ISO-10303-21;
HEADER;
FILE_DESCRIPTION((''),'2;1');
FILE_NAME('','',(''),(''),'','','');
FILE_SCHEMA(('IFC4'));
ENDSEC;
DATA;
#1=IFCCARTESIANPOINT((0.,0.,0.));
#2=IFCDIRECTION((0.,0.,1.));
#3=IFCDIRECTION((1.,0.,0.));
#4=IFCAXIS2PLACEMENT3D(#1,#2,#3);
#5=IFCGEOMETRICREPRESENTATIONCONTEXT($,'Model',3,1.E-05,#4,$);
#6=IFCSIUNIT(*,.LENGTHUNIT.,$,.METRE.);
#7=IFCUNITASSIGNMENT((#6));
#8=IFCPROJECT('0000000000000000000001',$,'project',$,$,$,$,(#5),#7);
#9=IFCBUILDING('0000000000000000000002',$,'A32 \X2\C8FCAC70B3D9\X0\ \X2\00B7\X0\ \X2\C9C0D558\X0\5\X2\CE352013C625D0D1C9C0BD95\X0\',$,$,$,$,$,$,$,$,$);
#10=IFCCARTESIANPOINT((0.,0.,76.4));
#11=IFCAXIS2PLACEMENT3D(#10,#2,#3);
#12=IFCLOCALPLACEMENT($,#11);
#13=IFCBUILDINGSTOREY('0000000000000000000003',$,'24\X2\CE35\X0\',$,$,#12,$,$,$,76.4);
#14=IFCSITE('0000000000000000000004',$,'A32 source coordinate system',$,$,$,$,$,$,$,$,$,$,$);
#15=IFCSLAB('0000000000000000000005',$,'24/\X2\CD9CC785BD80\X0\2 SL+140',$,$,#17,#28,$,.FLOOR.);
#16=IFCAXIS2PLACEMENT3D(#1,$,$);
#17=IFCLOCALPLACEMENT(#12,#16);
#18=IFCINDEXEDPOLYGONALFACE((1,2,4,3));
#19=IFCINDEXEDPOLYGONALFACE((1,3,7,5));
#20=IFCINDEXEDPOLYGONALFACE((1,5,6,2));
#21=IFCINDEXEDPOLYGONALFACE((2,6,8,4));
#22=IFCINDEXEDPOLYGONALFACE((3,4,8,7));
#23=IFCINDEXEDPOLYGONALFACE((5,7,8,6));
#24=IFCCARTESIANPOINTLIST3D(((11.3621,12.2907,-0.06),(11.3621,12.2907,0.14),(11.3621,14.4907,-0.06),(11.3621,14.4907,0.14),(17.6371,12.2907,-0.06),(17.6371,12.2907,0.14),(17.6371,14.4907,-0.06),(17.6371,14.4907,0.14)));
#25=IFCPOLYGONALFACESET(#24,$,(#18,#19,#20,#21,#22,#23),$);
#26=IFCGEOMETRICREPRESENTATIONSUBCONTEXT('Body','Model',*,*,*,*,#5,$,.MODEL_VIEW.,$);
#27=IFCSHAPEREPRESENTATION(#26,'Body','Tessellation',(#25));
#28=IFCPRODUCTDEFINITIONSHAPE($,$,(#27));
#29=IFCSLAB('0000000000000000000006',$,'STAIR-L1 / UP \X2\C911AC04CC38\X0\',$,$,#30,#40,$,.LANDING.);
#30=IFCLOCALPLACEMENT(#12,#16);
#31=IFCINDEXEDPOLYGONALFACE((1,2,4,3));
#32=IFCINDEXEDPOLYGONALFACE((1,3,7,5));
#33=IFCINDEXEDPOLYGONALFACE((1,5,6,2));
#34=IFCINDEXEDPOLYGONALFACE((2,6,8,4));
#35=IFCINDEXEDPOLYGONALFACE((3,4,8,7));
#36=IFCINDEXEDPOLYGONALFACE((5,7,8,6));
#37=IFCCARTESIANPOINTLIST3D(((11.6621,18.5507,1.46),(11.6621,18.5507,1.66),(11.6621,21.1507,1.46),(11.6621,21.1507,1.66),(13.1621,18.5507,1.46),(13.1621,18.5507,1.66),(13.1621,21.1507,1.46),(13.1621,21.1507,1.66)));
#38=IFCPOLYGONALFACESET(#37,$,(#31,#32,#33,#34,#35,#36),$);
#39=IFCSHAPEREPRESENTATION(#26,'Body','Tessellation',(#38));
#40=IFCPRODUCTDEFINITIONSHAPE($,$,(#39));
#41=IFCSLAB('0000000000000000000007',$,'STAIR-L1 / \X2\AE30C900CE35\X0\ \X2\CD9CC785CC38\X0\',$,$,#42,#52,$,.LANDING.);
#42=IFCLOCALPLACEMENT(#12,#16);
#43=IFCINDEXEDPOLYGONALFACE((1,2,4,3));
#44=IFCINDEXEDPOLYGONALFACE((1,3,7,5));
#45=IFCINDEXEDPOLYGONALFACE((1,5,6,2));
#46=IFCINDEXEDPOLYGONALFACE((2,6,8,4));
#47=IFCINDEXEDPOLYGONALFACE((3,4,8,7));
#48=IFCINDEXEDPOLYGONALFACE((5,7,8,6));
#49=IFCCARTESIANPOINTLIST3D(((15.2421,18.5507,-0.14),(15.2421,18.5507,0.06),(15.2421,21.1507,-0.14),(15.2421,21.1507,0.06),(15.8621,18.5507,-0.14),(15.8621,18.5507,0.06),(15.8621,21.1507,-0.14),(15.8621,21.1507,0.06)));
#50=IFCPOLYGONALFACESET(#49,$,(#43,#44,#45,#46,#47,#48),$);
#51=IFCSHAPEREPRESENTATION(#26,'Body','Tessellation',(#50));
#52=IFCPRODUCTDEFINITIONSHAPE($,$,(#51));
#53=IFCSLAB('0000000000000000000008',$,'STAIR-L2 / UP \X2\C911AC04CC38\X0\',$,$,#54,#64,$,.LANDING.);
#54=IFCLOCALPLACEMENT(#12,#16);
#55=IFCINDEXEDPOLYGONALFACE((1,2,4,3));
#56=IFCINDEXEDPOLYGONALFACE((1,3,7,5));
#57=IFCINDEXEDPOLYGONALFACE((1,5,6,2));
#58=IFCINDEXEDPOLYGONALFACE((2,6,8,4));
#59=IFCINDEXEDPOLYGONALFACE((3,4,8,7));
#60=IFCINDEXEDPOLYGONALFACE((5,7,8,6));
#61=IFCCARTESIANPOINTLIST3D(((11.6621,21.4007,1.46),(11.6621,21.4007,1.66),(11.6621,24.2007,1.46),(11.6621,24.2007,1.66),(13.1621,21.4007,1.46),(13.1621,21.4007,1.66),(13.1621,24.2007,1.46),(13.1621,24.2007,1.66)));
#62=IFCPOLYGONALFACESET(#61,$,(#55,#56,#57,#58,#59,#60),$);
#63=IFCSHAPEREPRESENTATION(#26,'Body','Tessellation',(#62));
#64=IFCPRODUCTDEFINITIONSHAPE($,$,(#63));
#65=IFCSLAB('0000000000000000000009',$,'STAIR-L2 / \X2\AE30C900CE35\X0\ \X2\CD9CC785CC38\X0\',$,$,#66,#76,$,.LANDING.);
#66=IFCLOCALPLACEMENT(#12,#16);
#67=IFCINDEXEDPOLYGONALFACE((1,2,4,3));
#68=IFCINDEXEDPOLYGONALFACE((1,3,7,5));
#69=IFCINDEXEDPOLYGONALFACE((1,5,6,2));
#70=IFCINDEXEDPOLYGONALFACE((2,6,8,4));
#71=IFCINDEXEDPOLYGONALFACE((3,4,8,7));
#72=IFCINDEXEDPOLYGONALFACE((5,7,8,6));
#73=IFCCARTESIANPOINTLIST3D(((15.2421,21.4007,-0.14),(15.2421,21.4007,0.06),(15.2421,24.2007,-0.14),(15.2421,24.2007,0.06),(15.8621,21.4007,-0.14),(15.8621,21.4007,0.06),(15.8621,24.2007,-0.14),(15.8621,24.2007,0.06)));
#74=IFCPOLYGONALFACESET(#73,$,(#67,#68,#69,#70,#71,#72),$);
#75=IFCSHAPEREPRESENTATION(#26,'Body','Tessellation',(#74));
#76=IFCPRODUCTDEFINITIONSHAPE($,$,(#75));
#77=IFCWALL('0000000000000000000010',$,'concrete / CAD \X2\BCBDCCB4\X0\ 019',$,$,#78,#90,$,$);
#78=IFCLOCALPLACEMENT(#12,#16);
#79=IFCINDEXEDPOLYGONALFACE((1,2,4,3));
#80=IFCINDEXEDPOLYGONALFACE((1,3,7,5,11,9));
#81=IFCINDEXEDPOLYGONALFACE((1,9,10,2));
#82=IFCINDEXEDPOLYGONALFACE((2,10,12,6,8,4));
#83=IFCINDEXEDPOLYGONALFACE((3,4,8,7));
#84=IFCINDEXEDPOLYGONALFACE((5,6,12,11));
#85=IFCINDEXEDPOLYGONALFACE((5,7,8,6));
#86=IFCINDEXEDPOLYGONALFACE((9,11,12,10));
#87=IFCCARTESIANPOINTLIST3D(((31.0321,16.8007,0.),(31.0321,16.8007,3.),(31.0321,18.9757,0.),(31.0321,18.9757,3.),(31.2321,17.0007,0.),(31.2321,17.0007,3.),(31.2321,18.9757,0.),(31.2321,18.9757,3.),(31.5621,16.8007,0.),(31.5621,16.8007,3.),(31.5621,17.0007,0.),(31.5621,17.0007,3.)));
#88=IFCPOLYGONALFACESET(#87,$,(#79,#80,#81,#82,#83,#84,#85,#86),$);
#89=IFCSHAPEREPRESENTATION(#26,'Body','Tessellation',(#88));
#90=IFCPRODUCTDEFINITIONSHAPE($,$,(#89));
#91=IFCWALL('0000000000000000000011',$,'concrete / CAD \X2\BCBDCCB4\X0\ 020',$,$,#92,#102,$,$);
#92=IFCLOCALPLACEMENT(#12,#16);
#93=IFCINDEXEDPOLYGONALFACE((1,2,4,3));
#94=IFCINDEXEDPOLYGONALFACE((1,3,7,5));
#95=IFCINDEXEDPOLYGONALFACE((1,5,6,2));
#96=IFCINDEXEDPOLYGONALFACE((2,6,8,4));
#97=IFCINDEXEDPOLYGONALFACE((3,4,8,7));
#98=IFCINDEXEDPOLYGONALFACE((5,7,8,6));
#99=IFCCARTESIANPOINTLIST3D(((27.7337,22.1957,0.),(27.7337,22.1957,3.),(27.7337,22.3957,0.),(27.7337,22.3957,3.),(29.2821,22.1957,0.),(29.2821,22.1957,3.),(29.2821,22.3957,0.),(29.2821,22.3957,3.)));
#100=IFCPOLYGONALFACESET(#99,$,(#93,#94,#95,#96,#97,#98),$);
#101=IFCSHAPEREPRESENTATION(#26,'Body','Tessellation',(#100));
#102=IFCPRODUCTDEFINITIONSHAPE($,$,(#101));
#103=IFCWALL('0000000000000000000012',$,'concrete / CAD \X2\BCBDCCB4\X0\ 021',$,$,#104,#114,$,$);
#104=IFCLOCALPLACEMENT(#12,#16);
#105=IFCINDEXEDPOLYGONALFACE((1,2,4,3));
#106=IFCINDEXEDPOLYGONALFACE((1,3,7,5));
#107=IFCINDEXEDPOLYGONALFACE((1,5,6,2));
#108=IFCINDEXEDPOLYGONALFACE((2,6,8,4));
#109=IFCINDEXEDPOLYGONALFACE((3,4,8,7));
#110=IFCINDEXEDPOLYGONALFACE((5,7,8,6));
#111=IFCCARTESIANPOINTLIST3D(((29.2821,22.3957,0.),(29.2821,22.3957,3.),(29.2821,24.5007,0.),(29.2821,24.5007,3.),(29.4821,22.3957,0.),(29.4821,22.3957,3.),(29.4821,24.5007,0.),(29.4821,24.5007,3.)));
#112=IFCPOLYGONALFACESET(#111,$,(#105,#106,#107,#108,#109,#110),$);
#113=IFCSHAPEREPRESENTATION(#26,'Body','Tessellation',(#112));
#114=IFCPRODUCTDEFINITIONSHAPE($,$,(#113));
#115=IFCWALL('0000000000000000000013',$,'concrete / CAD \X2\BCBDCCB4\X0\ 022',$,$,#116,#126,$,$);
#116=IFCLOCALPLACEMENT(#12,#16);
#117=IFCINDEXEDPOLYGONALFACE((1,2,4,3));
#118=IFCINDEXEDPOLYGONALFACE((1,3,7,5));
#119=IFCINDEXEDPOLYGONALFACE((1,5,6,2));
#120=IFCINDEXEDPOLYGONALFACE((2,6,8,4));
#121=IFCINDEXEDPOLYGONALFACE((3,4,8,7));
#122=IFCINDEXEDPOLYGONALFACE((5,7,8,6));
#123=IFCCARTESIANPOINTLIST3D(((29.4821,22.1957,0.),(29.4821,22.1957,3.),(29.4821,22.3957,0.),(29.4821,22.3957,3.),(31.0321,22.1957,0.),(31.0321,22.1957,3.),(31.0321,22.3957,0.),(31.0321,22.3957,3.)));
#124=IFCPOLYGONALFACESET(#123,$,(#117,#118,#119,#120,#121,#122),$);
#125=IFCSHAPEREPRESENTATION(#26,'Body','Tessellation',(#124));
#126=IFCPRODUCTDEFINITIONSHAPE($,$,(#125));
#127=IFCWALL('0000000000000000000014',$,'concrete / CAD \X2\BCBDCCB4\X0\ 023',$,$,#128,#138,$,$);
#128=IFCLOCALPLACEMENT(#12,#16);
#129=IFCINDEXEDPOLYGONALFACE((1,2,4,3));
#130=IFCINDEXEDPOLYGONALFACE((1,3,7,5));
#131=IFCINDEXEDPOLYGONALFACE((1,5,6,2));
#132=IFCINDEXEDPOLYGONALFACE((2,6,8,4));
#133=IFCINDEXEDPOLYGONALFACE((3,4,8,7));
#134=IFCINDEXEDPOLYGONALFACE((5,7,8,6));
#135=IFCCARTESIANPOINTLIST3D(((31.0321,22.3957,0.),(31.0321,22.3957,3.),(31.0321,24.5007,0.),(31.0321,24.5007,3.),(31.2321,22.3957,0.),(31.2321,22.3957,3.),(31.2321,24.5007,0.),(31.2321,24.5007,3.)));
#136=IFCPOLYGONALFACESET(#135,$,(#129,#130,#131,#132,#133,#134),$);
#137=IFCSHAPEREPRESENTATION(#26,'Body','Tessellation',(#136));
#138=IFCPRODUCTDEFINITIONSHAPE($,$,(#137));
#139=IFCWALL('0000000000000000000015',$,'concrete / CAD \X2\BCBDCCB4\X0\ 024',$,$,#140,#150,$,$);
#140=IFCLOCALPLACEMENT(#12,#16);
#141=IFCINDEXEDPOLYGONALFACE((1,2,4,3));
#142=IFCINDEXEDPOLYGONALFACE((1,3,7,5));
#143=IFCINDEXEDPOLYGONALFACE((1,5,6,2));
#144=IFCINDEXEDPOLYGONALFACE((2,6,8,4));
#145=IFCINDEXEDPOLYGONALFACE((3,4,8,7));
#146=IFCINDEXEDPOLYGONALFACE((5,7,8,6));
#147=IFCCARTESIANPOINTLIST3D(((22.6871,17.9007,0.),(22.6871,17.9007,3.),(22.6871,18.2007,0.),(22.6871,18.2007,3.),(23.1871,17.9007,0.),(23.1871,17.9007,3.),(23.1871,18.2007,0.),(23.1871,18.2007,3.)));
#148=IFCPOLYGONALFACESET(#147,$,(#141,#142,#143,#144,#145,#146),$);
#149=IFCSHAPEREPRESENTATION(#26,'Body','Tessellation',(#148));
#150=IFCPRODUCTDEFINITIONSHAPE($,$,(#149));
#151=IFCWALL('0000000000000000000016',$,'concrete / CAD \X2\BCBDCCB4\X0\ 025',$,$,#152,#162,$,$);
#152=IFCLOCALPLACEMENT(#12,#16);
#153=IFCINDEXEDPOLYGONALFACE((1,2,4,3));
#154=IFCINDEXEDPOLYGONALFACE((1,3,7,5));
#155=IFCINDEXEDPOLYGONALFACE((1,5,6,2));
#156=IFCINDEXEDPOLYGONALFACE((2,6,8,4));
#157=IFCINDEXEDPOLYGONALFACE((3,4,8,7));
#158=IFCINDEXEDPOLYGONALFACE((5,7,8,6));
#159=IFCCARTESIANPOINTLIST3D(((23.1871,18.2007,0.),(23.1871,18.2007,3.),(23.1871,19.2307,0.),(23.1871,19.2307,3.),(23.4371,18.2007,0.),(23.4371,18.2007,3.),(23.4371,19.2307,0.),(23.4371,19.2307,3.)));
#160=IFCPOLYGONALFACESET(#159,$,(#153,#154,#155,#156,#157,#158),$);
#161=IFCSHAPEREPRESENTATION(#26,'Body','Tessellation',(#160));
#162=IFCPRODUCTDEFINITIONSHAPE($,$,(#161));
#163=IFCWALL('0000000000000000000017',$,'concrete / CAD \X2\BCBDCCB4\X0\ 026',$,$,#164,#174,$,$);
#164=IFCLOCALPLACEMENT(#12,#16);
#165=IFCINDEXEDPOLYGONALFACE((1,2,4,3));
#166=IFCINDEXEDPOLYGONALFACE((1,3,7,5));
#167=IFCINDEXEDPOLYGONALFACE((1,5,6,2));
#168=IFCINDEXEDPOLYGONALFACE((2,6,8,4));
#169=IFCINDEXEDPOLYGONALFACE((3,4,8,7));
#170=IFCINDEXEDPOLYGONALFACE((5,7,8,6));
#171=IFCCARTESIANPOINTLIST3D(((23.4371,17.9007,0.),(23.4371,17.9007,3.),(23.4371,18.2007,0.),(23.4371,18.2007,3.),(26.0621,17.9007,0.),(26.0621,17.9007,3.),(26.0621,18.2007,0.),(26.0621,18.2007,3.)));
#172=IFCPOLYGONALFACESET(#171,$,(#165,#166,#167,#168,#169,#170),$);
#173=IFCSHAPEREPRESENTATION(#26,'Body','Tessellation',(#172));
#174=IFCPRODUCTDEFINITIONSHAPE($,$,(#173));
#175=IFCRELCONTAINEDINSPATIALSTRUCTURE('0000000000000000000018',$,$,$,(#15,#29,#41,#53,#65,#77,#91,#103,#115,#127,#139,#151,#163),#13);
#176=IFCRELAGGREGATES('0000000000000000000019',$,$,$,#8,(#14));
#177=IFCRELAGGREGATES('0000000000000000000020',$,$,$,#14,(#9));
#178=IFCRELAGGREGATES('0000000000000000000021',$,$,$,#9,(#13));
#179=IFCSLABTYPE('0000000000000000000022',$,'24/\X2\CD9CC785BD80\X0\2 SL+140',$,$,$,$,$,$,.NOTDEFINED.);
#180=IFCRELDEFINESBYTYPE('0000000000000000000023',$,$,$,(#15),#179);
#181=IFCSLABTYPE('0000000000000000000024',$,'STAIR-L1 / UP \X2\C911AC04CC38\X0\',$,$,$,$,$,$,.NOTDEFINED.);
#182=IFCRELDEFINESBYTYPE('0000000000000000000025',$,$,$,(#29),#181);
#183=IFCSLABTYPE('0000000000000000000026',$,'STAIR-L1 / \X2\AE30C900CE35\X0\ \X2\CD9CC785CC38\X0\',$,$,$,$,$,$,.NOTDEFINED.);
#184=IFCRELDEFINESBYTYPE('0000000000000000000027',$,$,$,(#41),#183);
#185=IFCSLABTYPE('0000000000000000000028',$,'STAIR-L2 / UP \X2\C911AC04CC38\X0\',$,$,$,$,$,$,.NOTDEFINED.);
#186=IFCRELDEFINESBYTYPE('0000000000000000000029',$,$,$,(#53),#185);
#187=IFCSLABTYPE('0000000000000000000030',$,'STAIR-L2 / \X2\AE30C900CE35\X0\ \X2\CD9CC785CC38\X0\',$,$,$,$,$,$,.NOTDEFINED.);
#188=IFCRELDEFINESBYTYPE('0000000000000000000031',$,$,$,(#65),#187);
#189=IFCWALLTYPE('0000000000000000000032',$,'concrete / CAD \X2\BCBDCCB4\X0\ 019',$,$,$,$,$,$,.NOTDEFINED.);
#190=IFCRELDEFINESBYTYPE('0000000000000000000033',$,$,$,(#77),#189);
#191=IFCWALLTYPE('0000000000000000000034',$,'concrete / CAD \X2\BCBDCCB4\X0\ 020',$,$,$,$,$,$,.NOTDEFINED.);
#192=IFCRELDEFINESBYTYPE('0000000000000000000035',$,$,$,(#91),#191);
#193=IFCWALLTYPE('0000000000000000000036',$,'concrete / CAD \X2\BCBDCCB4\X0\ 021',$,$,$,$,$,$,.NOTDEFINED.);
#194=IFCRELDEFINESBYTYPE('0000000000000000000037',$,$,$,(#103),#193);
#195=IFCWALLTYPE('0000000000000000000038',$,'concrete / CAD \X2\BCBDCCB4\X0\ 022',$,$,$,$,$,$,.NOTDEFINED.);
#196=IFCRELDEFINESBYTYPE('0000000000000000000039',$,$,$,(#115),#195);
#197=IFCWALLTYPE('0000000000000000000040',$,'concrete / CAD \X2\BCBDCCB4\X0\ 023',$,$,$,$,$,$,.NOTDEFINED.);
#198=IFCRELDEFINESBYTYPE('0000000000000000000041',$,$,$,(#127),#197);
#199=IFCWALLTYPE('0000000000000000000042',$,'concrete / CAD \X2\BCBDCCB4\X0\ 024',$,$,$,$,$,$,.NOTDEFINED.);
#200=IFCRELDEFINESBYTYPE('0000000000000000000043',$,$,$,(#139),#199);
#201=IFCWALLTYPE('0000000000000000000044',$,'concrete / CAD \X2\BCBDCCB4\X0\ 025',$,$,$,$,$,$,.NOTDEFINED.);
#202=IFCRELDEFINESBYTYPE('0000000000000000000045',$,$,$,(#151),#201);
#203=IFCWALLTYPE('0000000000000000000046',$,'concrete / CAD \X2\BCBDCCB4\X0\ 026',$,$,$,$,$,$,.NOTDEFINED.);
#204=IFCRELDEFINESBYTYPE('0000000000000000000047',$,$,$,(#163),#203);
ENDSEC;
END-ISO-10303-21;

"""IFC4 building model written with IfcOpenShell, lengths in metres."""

from ifc_helpers import new_model, si_unit, frame, origin, origin_with_axes, place, context, subcontext, project, spatial, polyline, outline, extrude, source, transform, mapped, type_object, type_shapes, element, save


model = new_model("IFC4")

# Units and contexts
model_context = context("Model", 3, precision=1e-05, world=origin_with_axes())
body_context = subcontext(model_context, "Body", "Model", "MODEL_VIEW")
ifc_project = project(units=[si_unit("LENGTHUNIT", "METRE")], contexts=[model_context])

# Site, building, storey
site = spatial("IfcSite", under=ifc_project, Name="A32 source coordinate system")
building = spatial("IfcBuilding", under=site, Name="A32 주거동 · 지하5층–옥탑지붕")
storey_placement = place(None, frame((0.0, 0.0, 76.4), z_axis=(0.0, 0.0, 1.0), x_axis=(1.0, 0.0, 0.0)))
storey = spatial("IfcBuildingStorey", under=building, at=storey_placement, Name="24층", Elevation=76.4)

# Slabs
slab_type_1 = type_object("IfcSlabType", Name="24/출입부2 SL+140", PredefinedType="NOTDEFINED")
shared_shape_1 = source(origin(), body_context, "Body", "SweptSolid", [
    extrude(outline(polyline([(17.6371, 12.2907), (11.3621, 12.2907), (11.3621, 14.4907), (17.6371, 14.4907), (17.6371, 12.2907)])), frame((0.0, 0.0, -0.06)), (0.0, 0.0, 1.0), 0.2),
])
type_shapes(slab_type_1, [shared_shape_1])
slab_1_placement = place(storey_placement, origin_with_axes())
element("IfcSlab", 1, at=slab_1_placement, inside=storey, type_object=slab_type_1, Name="24/출입부2 SL+140", PredefinedType="FLOOR", context=body_context, shape_type="MappedRepresentation", body=[
    mapped(shared_shape_1, transform((0.0, 0.0, 0.0), scale=1.0)),
])
slab_type_2 = type_object("IfcSlabType", Name="STAIR-L1 / UP 중간참", PredefinedType="NOTDEFINED")
shared_shape_2 = source(origin(), body_context, "Body", "SweptSolid", [
    extrude(outline(polyline([(11.6621, 18.5507), (11.6621, 21.1507), (13.1621, 21.1507), (13.1621, 18.5507), (11.6621, 18.5507)])), frame((0.0, 0.0, 1.46)), (0.0, 0.0, 1.0), 0.2),
])
type_shapes(slab_type_2, [shared_shape_2])
slab_2_placement = place(storey_placement, origin_with_axes())
element("IfcSlab", 2, at=slab_2_placement, inside=storey, type_object=slab_type_2, Name="STAIR-L1 / UP 중간참", PredefinedType="LANDING", context=body_context, shape_type="MappedRepresentation", body=[
    mapped(shared_shape_2, transform((0.0, 0.0, 0.0), scale=1.0)),
])
slab_type_3 = type_object("IfcSlabType", Name="STAIR-L1 / 기준층 출입참", PredefinedType="NOTDEFINED")
shared_shape_3 = source(origin(), body_context, "Body", "SweptSolid", [
    extrude(outline(polyline([(15.2421, 18.5507), (15.2421, 21.1507), (15.8621, 21.1507), (15.8621, 18.5507), (15.2421, 18.5507)])), frame((0.0, 0.0, -0.14)), (0.0, 0.0, 1.0), 0.2),
])
type_shapes(slab_type_3, [shared_shape_3])
slab_3_placement = place(storey_placement, origin_with_axes())
element("IfcSlab", 3, at=slab_3_placement, inside=storey, type_object=slab_type_3, Name="STAIR-L1 / 기준층 출입참", PredefinedType="LANDING", context=body_context, shape_type="MappedRepresentation", body=[
    mapped(shared_shape_3, transform((0.0, 0.0, 0.0), scale=1.0)),
])
slab_type_4 = type_object("IfcSlabType", Name="STAIR-L2 / UP 중간참", PredefinedType="NOTDEFINED")
shared_shape_4 = source(origin(), body_context, "Body", "SweptSolid", [
    extrude(outline(polyline([(11.6621, 21.4007), (11.6621, 24.2007), (13.1621, 24.2007), (13.1621, 21.4007), (11.6621, 21.4007)])), frame((0.0, 0.0, 1.46)), (0.0, 0.0, 1.0), 0.2),
])
type_shapes(slab_type_4, [shared_shape_4])
slab_4_placement = place(storey_placement, origin_with_axes())
element("IfcSlab", 4, at=slab_4_placement, inside=storey, type_object=slab_type_4, Name="STAIR-L2 / UP 중간참", PredefinedType="LANDING", context=body_context, shape_type="MappedRepresentation", body=[
    mapped(shared_shape_4, transform((0.0, 0.0, 0.0), scale=1.0)),
])
slab_type_5 = type_object("IfcSlabType", Name="STAIR-L2 / 기준층 출입참", PredefinedType="NOTDEFINED")
shared_shape_5 = source(origin(), body_context, "Body", "SweptSolid", [
    extrude(outline(polyline([(15.2421, 21.4007), (15.2421, 24.2007), (15.8621, 24.2007), (15.8621, 21.4007), (15.2421, 21.4007)])), frame((0.0, 0.0, -0.14)), (0.0, 0.0, 1.0), 0.2),
])
type_shapes(slab_type_5, [shared_shape_5])
slab_5_placement = place(storey_placement, origin_with_axes())
element("IfcSlab", 5, at=slab_5_placement, inside=storey, type_object=slab_type_5, Name="STAIR-L2 / 기준층 출입참", PredefinedType="LANDING", context=body_context, shape_type="MappedRepresentation", body=[
    mapped(shared_shape_5, transform((0.0, 0.0, 0.0), scale=1.0)),
])

# Walls
wall_type_1 = type_object("IfcWallType", Name="concrete / CAD 벽체 019", PredefinedType="NOTDEFINED")
shared_shape_6 = source(origin(), body_context, "Body", "SweptSolid", [
    extrude(outline(polyline([(31.2321, 17.0007), (31.5621, 17.0007), (31.5621, 16.8007), (31.0321, 16.8007), (31.0321, 18.9757), (31.2321, 18.9757), (31.2321, 17.0007)])), origin(), (0.0, 0.0, 1.0), 3.0),
])
type_shapes(wall_type_1, [shared_shape_6])
wall_1_placement = place(storey_placement, origin_with_axes())
element("IfcWall", 6, at=wall_1_placement, inside=storey, type_object=wall_type_1, Name="concrete / CAD 벽체 019", context=body_context, shape_type="MappedRepresentation", body=[
    mapped(shared_shape_6, transform((0.0, 0.0, 0.0), scale=1.0)),
])
wall_type_2 = type_object("IfcWallType", Name="concrete / CAD 벽체 020", PredefinedType="NOTDEFINED")
shared_shape_7 = source(origin(), body_context, "Body", "SweptSolid", [
    extrude(outline(polyline([(29.2821, 22.1957), (27.7337, 22.1957), (27.7337, 22.3957), (29.2821, 22.3957), (29.2821, 22.1957)])), origin(), (0.0, 0.0, 1.0), 3.0),
])
type_shapes(wall_type_2, [shared_shape_7])
wall_2_placement = place(storey_placement, origin_with_axes())
element("IfcWall", 7, at=wall_2_placement, inside=storey, type_object=wall_type_2, Name="concrete / CAD 벽체 020", context=body_context, shape_type="MappedRepresentation", body=[
    mapped(shared_shape_7, transform((0.0, 0.0, 0.0), scale=1.0)),
])
wall_type_3 = type_object("IfcWallType", Name="concrete / CAD 벽체 021", PredefinedType="NOTDEFINED")
shared_shape_8 = source(origin(), body_context, "Body", "SweptSolid", [
    extrude(outline(polyline([(29.4821, 22.3957), (29.2821, 22.3957), (29.2821, 24.5007), (29.4821, 24.5007), (29.4821, 22.3957)])), origin(), (0.0, 0.0, 1.0), 3.0),
])
type_shapes(wall_type_3, [shared_shape_8])
wall_3_placement = place(storey_placement, origin_with_axes())
element("IfcWall", 8, at=wall_3_placement, inside=storey, type_object=wall_type_3, Name="concrete / CAD 벽체 021", context=body_context, shape_type="MappedRepresentation", body=[
    mapped(shared_shape_8, transform((0.0, 0.0, 0.0), scale=1.0)),
])
wall_type_4 = type_object("IfcWallType", Name="concrete / CAD 벽체 022", PredefinedType="NOTDEFINED")
shared_shape_9 = source(origin(), body_context, "Body", "SweptSolid", [
    extrude(outline(polyline([(29.4821, 22.1957), (29.4821, 22.3957), (31.0321, 22.3957), (31.0321, 22.1957), (29.4821, 22.1957)])), origin(), (0.0, 0.0, 1.0), 3.0),
])
type_shapes(wall_type_4, [shared_shape_9])
wall_4_placement = place(storey_placement, origin_with_axes())
element("IfcWall", 9, at=wall_4_placement, inside=storey, type_object=wall_type_4, Name="concrete / CAD 벽체 022", context=body_context, shape_type="MappedRepresentation", body=[
    mapped(shared_shape_9, transform((0.0, 0.0, 0.0), scale=1.0)),
])
wall_type_5 = type_object("IfcWallType", Name="concrete / CAD 벽체 023", PredefinedType="NOTDEFINED")
shared_shape_10 = source(origin(), body_context, "Body", "SweptSolid", [
    extrude(outline(polyline([(31.2321, 22.3957), (31.0321, 22.3957), (31.0321, 24.5007), (31.2321, 24.5007), (31.2321, 22.3957)])), origin(), (0.0, 0.0, 1.0), 3.0),
])
type_shapes(wall_type_5, [shared_shape_10])
wall_5_placement = place(storey_placement, origin_with_axes())
element("IfcWall", 10, at=wall_5_placement, inside=storey, type_object=wall_type_5, Name="concrete / CAD 벽체 023", context=body_context, shape_type="MappedRepresentation", body=[
    mapped(shared_shape_10, transform((0.0, 0.0, 0.0), scale=1.0)),
])
wall_type_6 = type_object("IfcWallType", Name="concrete / CAD 벽체 024", PredefinedType="NOTDEFINED")
shared_shape_11 = source(origin(), body_context, "Body", "SweptSolid", [
    extrude(outline(polyline([(22.6871, 17.9007), (22.6871, 18.2007), (23.1871, 18.2007), (23.1871, 17.9007), (22.6871, 17.9007)])), origin(), (0.0, 0.0, 1.0), 3.0),
])
type_shapes(wall_type_6, [shared_shape_11])
wall_6_placement = place(storey_placement, origin_with_axes())
element("IfcWall", 11, at=wall_6_placement, inside=storey, type_object=wall_type_6, Name="concrete / CAD 벽체 024", context=body_context, shape_type="MappedRepresentation", body=[
    mapped(shared_shape_11, transform((0.0, 0.0, 0.0), scale=1.0)),
])
wall_type_7 = type_object("IfcWallType", Name="concrete / CAD 벽체 025", PredefinedType="NOTDEFINED")
shared_shape_12 = source(origin(), body_context, "Body", "SweptSolid", [
    extrude(outline(polyline([(23.4371, 18.2007), (23.1871, 18.2007), (23.1871, 19.2307), (23.4371, 19.2307), (23.4371, 18.2007)])), origin(), (0.0, 0.0, 1.0), 3.0),
])
type_shapes(wall_type_7, [shared_shape_12])
wall_7_placement = place(storey_placement, origin_with_axes())
element("IfcWall", 12, at=wall_7_placement, inside=storey, type_object=wall_type_7, Name="concrete / CAD 벽체 025", context=body_context, shape_type="MappedRepresentation", body=[
    mapped(shared_shape_12, transform((0.0, 0.0, 0.0), scale=1.0)),
])
wall_type_8 = type_object("IfcWallType", Name="concrete / CAD 벽체 026", PredefinedType="NOTDEFINED")
shared_shape_13 = source(origin(), body_context, "Body", "SweptSolid", [
    extrude(outline(polyline([(23.4371, 17.9007), (23.4371, 18.2007), (26.0621, 18.2007), (26.0621, 17.9007), (23.4371, 17.9007)])), origin(), (0.0, 0.0, 1.0), 3.0),
])
type_shapes(wall_type_8, [shared_shape_13])
wall_8_placement = place(storey_placement, origin_with_axes())
element("IfcWall", 13, at=wall_8_placement, inside=storey, type_object=wall_type_8, Name="concrete / CAD 벽체 026", context=body_context, shape_type="MappedRepresentation", body=[
    mapped(shared_shape_13, transform((0.0, 0.0, 0.0), scale=1.0)),
])

save(model, "model.ifc")
